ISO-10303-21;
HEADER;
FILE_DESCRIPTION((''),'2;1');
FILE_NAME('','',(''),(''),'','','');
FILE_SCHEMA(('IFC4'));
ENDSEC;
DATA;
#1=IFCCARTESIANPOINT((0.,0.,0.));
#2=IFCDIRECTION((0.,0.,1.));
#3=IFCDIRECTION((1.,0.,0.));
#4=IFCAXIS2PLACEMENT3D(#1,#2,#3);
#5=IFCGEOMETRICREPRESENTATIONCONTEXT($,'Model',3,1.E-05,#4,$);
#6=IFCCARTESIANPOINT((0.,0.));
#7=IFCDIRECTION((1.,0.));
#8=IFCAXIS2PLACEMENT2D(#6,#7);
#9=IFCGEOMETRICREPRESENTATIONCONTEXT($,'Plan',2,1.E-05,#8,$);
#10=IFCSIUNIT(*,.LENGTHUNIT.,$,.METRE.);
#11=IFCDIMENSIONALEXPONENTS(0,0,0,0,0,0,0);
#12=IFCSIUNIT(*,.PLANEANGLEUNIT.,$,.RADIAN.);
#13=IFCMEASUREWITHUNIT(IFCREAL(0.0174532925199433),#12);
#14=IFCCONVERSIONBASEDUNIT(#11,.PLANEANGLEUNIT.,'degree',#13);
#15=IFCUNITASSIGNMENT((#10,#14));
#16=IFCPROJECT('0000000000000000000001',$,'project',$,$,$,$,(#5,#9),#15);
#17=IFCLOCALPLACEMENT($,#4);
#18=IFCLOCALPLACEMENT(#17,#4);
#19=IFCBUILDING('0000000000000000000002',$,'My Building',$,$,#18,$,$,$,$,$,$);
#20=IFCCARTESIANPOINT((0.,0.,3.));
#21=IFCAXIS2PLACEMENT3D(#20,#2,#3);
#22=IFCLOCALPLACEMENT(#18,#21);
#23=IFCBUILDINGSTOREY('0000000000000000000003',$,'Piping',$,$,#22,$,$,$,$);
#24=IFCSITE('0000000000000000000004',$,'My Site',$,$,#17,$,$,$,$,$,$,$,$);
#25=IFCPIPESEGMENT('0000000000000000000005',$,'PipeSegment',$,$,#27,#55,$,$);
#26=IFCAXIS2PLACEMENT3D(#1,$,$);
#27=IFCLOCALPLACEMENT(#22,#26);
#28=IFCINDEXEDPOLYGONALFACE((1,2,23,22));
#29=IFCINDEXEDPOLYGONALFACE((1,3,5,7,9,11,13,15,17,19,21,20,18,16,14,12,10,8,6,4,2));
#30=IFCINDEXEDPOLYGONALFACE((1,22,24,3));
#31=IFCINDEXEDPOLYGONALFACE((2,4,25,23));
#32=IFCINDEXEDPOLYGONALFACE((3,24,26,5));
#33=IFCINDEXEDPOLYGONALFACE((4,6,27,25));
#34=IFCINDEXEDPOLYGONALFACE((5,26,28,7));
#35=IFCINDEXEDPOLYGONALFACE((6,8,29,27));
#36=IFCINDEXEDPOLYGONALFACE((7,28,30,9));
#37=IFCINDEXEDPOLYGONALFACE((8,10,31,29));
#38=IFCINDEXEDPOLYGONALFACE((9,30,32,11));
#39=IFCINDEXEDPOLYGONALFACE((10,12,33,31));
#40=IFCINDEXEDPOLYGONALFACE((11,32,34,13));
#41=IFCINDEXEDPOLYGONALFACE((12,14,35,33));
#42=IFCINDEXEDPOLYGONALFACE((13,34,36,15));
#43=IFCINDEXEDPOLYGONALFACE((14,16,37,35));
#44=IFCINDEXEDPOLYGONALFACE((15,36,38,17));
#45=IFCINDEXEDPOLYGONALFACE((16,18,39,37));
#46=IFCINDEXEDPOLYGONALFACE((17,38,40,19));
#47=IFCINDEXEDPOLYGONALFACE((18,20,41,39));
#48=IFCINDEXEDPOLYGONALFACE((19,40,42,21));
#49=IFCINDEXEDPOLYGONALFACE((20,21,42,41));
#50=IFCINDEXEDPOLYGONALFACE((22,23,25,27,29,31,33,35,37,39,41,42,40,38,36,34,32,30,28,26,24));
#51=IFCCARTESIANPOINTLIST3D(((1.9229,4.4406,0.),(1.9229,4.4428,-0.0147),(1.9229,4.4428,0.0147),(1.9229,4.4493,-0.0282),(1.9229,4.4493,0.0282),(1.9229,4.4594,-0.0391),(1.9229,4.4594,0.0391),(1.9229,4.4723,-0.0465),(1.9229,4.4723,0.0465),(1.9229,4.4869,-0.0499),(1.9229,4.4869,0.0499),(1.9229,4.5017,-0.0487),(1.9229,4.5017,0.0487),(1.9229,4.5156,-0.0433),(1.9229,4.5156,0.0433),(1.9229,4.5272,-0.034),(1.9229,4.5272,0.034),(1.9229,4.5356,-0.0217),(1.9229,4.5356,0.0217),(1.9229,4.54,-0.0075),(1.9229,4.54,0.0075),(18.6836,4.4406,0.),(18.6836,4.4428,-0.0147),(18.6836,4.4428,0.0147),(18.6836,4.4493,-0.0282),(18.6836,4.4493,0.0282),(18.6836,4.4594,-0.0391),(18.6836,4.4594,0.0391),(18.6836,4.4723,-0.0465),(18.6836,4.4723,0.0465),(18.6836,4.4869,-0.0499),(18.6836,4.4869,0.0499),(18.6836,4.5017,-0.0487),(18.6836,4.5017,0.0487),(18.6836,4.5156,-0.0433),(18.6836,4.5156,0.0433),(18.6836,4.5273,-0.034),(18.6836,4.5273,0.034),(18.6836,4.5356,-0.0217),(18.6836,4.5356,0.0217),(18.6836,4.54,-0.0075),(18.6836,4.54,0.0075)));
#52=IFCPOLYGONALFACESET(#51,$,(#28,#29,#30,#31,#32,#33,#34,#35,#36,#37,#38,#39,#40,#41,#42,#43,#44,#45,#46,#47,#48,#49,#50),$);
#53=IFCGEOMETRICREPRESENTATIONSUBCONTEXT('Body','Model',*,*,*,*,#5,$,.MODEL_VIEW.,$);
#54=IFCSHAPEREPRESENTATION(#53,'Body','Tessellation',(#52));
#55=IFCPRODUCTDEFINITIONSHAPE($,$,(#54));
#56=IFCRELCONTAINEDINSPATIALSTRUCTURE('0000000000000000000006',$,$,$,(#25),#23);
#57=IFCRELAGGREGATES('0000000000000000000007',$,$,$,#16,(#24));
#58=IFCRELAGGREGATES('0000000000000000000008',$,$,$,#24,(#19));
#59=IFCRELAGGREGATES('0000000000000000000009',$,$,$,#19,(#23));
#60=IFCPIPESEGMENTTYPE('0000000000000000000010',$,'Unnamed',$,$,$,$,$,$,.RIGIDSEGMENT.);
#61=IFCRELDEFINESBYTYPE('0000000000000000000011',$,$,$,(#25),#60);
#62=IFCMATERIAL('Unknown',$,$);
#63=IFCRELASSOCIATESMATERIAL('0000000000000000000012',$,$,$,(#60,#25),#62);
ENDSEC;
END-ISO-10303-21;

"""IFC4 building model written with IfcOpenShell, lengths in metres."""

from ifc_helpers import new_model, entity, si_unit, converted_unit, frame, origin_with_axes, origin_2d_with_axis, place, context, subcontext, project, spatial, circle, extrude, material, material_profile, profile_set, profile_usage, type_object, element, save


model = new_model("IFC4")

# Units and contexts
model_context = context("Model", 3, precision=1e-05, world=origin_with_axes())
plan_context = context("Plan", 2, precision=1e-05, world=origin_2d_with_axis())
body_context = subcontext(model_context, "Body", "Model", "MODEL_VIEW")
ifc_project = project(units=[si_unit("LENGTHUNIT", "METRE"), converted_unit("PLANEANGLEUNIT", "degree", entity("IfcReal", 0.0174532925199433), si_unit("PLANEANGLEUNIT", "RADIAN"), dimensions=[0, 0, 0, 0, 0, 0, 0])], contexts=[model_context, plan_context])

# Site, building, storey
site_placement = place(None, origin_with_axes())
site = spatial("IfcSite", under=ifc_project, at=site_placement, Name="My Site")
building_placement = place(site_placement, origin_with_axes())
building = spatial("IfcBuilding", under=site, at=building_placement, Name="My Building")
storey_placement = place(building_placement, frame((0.0, 0.0, 3.0), z_axis=(0.0, 0.0, 1.0), x_axis=(1.0, 0.0, 0.0)))
storey = spatial("IfcBuildingStorey", under=building, at=storey_placement, Name="Piping")

# Pipe segment
ifc_material = material(Name="Unknown")
ifc_material_profile = material_profile(ifc_material, circle(Radius=0.05))
ifc_profile_set = profile_set([ifc_material_profile])
ifc_profile_usage = profile_usage(ifc_profile_set, cardinal=5)
pipe_segment_type = type_object("IfcPipeSegmentType", Name="Unnamed", PredefinedType="RIGIDSEGMENT", material=ifc_profile_set)
pipe_segment_placement = place(storey_placement, frame((18.6836, 4.4906, 0.0), z_axis=(-1.0, 0.0, 0.0), x_axis=(0.0, -1.0, 0.0)))
element("IfcPipeSegment", 1, at=pipe_segment_placement, inside=storey, type_object=pipe_segment_type, material=ifc_profile_usage, Name="PipeSegment", context=body_context, shape_type="SweptSolid", body=[
    extrude(circle(Radius=0.05), origin_with_axes(), (0.0, 0.0, 1.0), 16.7607),
])

save(model, "model.ifc")
